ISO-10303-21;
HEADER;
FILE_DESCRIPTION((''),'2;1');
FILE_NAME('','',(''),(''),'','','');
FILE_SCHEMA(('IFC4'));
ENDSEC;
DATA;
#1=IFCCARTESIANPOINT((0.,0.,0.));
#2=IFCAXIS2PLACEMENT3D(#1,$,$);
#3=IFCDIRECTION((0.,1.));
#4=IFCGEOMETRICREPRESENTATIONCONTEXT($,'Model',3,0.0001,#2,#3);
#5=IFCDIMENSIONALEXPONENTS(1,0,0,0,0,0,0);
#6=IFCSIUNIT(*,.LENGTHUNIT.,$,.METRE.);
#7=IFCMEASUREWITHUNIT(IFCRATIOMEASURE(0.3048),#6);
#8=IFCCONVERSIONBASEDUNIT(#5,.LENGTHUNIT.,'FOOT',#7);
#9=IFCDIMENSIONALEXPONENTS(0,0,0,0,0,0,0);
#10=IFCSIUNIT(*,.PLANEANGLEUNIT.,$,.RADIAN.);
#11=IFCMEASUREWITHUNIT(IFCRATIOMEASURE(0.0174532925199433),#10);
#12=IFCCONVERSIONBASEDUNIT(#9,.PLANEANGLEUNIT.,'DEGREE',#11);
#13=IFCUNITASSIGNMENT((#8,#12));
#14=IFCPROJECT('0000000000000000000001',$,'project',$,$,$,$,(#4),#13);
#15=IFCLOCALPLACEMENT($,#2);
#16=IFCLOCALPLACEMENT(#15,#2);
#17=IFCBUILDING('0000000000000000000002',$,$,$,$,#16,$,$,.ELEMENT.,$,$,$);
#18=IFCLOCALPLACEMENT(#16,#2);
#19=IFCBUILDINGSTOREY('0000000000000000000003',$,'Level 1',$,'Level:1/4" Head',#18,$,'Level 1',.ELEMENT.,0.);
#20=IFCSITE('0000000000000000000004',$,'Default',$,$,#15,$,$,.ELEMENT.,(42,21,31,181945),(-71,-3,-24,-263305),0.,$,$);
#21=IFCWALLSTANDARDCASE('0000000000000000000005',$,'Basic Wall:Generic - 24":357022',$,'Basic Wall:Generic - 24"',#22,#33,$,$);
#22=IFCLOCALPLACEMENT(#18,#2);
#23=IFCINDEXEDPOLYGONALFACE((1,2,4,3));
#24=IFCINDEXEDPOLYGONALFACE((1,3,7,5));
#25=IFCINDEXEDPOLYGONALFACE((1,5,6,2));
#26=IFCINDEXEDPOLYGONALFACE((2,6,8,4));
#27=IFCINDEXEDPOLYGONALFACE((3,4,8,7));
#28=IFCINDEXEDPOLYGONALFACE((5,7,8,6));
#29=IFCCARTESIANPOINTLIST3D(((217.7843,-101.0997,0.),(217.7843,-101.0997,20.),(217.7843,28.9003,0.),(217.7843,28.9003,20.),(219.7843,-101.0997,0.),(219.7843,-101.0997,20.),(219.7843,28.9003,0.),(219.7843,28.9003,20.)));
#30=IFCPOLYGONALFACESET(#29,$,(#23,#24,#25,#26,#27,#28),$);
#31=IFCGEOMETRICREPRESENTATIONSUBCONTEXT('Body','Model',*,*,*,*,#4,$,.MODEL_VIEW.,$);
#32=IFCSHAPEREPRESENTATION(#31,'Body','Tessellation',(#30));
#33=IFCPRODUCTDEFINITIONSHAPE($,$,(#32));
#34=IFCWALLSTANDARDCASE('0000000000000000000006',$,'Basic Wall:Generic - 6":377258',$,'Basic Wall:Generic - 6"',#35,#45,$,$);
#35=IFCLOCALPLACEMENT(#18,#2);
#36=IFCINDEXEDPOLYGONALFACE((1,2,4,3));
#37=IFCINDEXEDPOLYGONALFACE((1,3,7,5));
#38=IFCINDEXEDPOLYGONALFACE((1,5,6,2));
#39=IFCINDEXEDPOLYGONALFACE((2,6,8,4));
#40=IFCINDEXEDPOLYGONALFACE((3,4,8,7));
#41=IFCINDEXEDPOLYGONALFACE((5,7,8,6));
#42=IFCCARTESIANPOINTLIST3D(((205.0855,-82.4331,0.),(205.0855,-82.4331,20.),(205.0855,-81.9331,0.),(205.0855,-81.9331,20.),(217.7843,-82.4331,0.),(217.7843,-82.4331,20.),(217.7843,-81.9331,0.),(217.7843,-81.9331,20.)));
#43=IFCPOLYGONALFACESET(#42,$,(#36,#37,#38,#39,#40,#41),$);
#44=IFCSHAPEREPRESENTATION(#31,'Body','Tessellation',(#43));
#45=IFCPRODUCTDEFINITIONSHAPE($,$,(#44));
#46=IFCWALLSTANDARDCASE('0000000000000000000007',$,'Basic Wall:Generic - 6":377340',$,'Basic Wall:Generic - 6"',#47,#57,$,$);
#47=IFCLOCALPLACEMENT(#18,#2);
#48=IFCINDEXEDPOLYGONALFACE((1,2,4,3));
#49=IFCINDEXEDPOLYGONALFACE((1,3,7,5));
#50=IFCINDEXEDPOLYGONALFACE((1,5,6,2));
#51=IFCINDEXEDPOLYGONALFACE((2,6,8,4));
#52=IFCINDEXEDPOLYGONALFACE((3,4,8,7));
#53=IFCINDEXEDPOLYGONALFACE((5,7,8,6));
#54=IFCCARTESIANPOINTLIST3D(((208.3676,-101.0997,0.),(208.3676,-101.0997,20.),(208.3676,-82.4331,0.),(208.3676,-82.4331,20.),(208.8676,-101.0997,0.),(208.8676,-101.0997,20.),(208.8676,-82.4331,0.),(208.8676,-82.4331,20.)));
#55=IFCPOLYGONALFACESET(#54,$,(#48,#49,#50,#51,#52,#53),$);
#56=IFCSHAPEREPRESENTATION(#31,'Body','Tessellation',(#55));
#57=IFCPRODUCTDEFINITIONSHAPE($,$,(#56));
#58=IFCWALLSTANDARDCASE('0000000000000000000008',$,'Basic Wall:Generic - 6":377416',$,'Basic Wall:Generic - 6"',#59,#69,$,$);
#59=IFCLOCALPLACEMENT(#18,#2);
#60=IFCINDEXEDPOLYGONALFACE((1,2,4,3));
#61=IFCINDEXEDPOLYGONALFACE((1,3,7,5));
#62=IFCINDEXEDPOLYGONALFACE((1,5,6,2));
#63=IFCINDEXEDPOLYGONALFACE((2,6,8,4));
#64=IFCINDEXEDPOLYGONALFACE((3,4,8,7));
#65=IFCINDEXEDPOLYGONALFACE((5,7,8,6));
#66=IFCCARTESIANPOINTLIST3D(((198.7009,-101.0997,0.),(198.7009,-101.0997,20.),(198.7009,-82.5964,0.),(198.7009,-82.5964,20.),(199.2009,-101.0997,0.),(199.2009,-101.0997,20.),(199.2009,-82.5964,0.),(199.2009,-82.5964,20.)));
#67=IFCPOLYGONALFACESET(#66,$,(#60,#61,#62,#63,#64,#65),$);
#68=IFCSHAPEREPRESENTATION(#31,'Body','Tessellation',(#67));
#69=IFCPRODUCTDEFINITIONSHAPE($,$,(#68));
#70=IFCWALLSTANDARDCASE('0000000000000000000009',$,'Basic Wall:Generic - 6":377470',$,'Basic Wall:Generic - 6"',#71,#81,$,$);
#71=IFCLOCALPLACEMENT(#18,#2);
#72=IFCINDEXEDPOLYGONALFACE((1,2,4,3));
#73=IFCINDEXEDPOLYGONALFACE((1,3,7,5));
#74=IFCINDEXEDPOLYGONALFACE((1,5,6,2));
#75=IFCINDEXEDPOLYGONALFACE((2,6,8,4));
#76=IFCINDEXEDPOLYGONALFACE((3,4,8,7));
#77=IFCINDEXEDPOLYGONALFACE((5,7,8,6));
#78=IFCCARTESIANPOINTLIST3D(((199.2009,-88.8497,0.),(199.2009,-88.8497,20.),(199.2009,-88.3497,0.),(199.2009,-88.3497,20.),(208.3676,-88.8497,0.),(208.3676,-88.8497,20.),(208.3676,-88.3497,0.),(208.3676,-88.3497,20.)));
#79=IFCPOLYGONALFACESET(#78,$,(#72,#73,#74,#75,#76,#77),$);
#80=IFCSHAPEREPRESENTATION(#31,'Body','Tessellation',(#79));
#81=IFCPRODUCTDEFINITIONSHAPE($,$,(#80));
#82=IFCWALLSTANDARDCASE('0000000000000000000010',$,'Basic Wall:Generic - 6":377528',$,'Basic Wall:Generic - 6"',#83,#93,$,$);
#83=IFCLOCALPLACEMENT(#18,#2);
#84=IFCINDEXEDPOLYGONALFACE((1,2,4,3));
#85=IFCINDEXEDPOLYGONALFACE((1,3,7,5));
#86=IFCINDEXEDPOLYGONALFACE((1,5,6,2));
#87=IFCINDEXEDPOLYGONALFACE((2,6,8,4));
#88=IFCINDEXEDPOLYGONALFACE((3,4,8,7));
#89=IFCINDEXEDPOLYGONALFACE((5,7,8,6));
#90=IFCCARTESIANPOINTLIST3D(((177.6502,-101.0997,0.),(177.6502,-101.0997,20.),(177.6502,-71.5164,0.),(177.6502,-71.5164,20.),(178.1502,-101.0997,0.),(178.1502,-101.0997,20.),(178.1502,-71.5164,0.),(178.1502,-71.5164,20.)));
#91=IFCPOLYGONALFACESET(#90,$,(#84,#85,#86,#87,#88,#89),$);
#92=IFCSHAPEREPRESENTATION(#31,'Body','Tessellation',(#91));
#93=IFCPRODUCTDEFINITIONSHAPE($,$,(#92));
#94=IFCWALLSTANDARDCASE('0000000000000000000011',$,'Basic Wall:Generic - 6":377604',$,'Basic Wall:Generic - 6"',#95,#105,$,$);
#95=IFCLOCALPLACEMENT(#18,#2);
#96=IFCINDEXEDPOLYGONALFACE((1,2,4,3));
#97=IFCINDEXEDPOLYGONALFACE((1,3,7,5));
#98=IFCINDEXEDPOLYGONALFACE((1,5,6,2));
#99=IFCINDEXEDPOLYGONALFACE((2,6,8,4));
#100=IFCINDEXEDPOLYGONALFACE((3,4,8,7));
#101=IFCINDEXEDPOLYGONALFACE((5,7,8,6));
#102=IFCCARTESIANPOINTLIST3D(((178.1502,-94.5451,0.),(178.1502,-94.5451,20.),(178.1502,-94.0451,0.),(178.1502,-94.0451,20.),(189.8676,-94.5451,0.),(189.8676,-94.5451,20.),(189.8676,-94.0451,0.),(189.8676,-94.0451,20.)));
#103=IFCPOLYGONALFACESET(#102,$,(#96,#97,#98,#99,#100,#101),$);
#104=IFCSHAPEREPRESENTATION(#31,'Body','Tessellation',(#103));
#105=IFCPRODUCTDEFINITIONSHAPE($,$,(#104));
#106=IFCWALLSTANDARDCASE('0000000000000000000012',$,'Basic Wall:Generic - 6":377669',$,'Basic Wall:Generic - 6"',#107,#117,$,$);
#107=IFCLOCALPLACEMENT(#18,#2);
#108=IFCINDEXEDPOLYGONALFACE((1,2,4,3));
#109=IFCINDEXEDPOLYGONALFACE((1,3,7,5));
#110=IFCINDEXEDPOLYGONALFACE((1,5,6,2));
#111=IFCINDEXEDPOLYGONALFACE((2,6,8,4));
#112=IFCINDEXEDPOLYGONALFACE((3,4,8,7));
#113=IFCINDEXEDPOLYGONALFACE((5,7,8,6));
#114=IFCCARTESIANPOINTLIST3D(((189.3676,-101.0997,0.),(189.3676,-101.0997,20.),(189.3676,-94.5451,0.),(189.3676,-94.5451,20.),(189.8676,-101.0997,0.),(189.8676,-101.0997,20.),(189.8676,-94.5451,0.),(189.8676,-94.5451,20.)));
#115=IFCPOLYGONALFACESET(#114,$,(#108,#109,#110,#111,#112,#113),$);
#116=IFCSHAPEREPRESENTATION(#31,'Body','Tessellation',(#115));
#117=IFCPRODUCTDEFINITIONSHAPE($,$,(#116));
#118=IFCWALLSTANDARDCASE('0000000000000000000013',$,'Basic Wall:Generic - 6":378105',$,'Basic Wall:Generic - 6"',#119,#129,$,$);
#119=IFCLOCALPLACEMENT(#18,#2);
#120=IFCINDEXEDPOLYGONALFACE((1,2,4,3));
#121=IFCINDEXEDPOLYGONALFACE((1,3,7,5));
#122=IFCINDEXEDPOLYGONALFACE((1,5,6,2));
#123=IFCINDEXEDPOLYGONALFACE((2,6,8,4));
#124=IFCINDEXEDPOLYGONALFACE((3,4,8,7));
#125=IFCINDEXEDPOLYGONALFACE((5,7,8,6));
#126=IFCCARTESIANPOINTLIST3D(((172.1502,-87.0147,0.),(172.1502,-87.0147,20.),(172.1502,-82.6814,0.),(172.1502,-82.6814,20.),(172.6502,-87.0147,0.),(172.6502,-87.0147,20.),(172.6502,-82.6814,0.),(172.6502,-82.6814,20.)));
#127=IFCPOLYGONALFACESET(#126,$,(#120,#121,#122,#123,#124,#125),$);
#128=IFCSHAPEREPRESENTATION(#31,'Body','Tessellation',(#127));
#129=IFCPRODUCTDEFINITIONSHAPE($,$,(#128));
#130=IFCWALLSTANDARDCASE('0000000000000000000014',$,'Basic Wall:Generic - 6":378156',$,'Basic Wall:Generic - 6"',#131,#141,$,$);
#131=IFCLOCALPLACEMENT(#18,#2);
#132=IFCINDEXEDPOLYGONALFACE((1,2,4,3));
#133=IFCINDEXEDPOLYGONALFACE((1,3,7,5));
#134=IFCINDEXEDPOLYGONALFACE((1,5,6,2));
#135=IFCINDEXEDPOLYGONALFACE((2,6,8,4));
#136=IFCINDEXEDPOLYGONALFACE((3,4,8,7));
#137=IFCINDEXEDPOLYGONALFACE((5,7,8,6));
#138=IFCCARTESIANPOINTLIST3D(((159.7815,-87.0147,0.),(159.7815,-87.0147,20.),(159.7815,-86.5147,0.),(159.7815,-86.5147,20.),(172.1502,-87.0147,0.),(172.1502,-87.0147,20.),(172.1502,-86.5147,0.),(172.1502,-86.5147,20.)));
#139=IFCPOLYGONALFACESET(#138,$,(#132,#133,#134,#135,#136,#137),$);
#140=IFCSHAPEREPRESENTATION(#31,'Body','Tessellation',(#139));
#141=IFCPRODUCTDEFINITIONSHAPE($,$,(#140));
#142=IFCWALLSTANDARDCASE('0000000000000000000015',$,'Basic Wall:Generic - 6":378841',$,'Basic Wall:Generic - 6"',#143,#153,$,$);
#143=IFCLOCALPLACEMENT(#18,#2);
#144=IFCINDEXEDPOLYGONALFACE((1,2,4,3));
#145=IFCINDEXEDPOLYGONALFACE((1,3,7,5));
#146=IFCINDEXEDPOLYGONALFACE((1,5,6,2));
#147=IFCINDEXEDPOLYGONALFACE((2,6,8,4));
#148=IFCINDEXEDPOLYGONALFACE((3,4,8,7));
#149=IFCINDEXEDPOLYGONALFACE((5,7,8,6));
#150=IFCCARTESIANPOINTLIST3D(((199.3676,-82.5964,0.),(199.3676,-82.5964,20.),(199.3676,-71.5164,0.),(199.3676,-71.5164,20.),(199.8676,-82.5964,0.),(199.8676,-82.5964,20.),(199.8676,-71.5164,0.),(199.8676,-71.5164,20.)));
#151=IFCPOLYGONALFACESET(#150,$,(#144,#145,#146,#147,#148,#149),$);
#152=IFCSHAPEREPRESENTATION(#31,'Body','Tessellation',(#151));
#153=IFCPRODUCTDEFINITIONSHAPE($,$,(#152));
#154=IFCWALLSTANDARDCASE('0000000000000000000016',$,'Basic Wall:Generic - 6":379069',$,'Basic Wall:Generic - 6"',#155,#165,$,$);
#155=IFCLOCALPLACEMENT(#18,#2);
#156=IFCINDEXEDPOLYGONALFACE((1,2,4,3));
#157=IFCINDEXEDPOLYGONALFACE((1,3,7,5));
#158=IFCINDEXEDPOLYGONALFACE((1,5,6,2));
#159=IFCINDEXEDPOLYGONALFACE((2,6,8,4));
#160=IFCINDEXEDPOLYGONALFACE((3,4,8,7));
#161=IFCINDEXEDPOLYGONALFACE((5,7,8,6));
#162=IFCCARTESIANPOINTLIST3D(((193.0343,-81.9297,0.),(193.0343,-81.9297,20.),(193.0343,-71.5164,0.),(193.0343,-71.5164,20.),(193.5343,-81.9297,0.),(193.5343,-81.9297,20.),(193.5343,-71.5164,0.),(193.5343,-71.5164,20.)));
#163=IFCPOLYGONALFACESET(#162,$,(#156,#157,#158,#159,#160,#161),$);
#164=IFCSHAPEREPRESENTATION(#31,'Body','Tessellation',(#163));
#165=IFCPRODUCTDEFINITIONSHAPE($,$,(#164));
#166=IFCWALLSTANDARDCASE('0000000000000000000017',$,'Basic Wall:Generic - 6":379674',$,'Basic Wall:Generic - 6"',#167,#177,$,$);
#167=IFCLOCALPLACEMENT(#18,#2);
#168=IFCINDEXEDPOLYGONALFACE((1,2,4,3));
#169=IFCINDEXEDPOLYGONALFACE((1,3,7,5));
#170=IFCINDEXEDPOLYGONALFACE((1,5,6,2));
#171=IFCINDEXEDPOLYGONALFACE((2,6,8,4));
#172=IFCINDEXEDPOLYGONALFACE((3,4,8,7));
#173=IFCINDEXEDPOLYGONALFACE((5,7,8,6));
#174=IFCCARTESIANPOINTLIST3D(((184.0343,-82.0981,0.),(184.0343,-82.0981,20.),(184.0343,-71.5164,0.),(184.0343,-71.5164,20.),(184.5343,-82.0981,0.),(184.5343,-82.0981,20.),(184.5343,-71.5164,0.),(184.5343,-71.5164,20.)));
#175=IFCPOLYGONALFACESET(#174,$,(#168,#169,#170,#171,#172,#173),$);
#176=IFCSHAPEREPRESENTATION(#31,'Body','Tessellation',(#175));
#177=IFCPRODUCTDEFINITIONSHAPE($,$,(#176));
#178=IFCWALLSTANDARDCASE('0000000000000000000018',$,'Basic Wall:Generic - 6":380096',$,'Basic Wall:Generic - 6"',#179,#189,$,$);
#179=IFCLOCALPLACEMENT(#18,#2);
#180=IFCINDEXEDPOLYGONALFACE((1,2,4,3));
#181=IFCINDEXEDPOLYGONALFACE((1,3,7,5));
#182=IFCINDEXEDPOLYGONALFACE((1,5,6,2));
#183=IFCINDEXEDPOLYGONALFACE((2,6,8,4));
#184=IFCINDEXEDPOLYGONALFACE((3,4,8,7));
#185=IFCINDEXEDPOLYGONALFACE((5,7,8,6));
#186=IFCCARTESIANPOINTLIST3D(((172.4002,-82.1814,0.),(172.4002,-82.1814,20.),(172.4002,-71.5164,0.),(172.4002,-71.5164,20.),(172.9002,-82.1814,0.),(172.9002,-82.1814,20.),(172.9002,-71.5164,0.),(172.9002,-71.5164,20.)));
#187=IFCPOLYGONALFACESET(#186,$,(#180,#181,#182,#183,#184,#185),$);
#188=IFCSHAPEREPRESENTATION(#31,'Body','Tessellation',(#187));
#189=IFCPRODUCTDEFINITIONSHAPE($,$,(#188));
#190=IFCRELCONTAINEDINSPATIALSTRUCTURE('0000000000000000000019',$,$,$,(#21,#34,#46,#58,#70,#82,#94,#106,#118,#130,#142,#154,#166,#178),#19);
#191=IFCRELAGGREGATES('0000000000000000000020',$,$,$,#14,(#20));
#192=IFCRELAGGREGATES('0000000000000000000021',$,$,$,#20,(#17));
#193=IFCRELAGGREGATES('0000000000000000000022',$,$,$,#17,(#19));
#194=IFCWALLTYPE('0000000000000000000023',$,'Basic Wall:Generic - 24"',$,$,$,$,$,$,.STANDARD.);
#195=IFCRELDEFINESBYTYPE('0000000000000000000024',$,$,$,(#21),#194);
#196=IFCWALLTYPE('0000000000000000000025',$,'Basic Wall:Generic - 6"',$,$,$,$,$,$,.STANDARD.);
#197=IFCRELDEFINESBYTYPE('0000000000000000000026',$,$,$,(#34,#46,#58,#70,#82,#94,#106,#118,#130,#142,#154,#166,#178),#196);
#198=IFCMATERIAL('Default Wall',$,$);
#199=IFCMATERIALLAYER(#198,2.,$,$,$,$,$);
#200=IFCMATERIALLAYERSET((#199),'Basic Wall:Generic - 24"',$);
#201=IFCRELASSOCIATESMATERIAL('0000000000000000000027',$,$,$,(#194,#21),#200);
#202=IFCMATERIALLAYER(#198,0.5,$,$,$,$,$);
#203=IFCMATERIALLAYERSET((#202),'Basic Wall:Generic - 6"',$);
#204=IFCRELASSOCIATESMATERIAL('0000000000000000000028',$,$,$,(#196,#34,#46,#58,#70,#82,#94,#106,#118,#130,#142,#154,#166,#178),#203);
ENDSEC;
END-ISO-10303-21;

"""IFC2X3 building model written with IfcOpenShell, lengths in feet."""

from ifc_helpers import new_model, entity, si_unit, converted_unit, direction, frame, frame_2d, origin, place, context, subcontext, project, spatial, rectangle, extrude, material, layer, layer_set, layer_usage, type_object, element, save


model = new_model("IFC2X3")

# Units and contexts
model_context = context("Model", 3, precision=0.0001, world=origin(), true_north=direction((0.0, 1.0)))
body_context = subcontext(model_context, "Body", "Model", "MODEL_VIEW")
ifc_project = project(units=[converted_unit("LENGTHUNIT", "FOOT", entity("IfcRatioMeasure", 0.3048), si_unit("LENGTHUNIT", "METRE"), dimensions=[1, 0, 0, 0, 0, 0, 0]), converted_unit("PLANEANGLEUNIT", "DEGREE", entity("IfcRatioMeasure", 0.0174532925199433), si_unit("PLANEANGLEUNIT", "RADIAN"), dimensions=[0, 0, 0, 0, 0, 0, 0])], contexts=[model_context])

# Site, building, storey
site_placement = place(None, origin())
site = spatial("IfcSite", under=ifc_project, at=site_placement, Name="Default", CompositionType="ELEMENT", RefLatitude=(42, 21, 31, 181945), RefLongitude=(-71, -3, -24, -263305), RefElevation=0.0)
building_placement = place(site_placement, origin())
building = spatial("IfcBuilding", under=site, at=building_placement, CompositionType="ELEMENT")
storey_placement = place(building_placement, origin())
storey = spatial("IfcBuildingStorey", under=building, at=storey_placement, Name="Level 1", ObjectType="Level:1/4\" Head", LongName="Level 1", CompositionType="ELEMENT", Elevation=0.0)

# Walls
ifc_material = material(Name="Default Wall")
ifc_layer_1 = layer(ifc_material, 2.0)
ifc_layer_set_1 = layer_set([ifc_layer_1], Name="Basic Wall:Generic - 24\"")
ifc_layer_usage_1 = layer_usage(ifc_layer_set_1, "AXIS2", "NEGATIVE", 1.0)
wall_type_1 = type_object("IfcWallType", Name="Basic Wall:Generic - 24\"", PredefinedType="STANDARD", material=ifc_layer_set_1)
wall_1_placement = place(storey_placement, frame((218.7843, -101.0997, 0.0), z_axis=(0.0, 0.0, 1.0), x_axis=(0.0, 1.0, 0.0)))
element("IfcWallStandardCase", 1, at=wall_1_placement, inside=storey, type_object=wall_type_1, material=ifc_layer_usage_1, Name="Basic Wall:Generic - 24\":357022", ObjectType="Basic Wall:Generic - 24\"", context=body_context, shape_type="SweptSolid", body=[
    extrude(rectangle(XDim=130.0, YDim=2.0, at=frame_2d((65.0, 0.0), x_axis=(-1.0, 0.0))), origin(), (0.0, 0.0, 1.0), 20.0),
])
ifc_layer_2 = layer(ifc_material, 0.5)
ifc_layer_set_2 = layer_set([ifc_layer_2], Name="Basic Wall:Generic - 6\"")
ifc_layer_usage_2 = layer_usage(ifc_layer_set_2, "AXIS2", "NEGATIVE", 0.25)
wall_type_2 = type_object("IfcWallType", Name="Basic Wall:Generic - 6\"", PredefinedType="STANDARD", material=ifc_layer_set_2)
wall_2_placement = place(storey_placement, frame((205.0855, -82.1831, 0.0)))
element("IfcWallStandardCase", 2, at=wall_2_placement, inside=storey, type_object=wall_type_2, material=ifc_layer_usage_2, Name="Basic Wall:Generic - 6\":377258", ObjectType="Basic Wall:Generic - 6\"", context=body_context, shape_type="SweptSolid", body=[
    extrude(rectangle(XDim=12.6987, YDim=0.5, at=frame_2d((6.3494, 0.0), x_axis=(-1.0, 0.0))), origin(), (0.0, 0.0, 1.0), 20.0),
])
ifc_layer_usage_3 = layer_usage(ifc_layer_set_2, "AXIS2", "NEGATIVE", 0.25)
wall_3_placement = place(storey_placement, frame((208.6176, -101.0997, 0.0), z_axis=(0.0, 0.0, 1.0), x_axis=(0.0, 1.0, 0.0)))
element("IfcWallStandardCase", 3, at=wall_3_placement, inside=storey, type_object=wall_type_2, material=ifc_layer_usage_3, Name="Basic Wall:Generic - 6\":377340", ObjectType="Basic Wall:Generic - 6\"", context=body_context, shape_type="SweptSolid", body=[
    extrude(rectangle(XDim=18.6667, YDim=0.5, at=frame_2d((9.3333, 0.0), x_axis=(-1.0, 0.0))), origin(), (0.0, 0.0, 1.0), 20.0),
])
ifc_layer_usage_4 = layer_usage(ifc_layer_set_2, "AXIS2", "NEGATIVE", 0.25)
wall_4_placement = place(storey_placement, frame((198.9509, -82.5964, 0.0), z_axis=(0.0, 0.0, 1.0), x_axis=(0.0, -1.0, 0.0)))
element("IfcWallStandardCase", 4, at=wall_4_placement, inside=storey, type_object=wall_type_2, material=ifc_layer_usage_4, Name="Basic Wall:Generic - 6\":377416", ObjectType="Basic Wall:Generic - 6\"", context=body_context, shape_type="SweptSolid", body=[
    extrude(rectangle(XDim=18.5033, YDim=0.5, at=frame_2d((9.2517, 0.0), x_axis=(-1.0, 0.0))), origin(), (0.0, 0.0, 1.0), 20.0),
])
ifc_layer_usage_5 = layer_usage(ifc_layer_set_2, "AXIS2", "NEGATIVE", 0.25)
wall_5_placement = place(storey_placement, frame((199.2009, -88.5997, 0.0)))
element("IfcWallStandardCase", 5, at=wall_5_placement, inside=storey, type_object=wall_type_2, material=ifc_layer_usage_5, Name="Basic Wall:Generic - 6\":377470", ObjectType="Basic Wall:Generic - 6\"", context=body_context, shape_type="SweptSolid", body=[
    extrude(rectangle(XDim=9.1667, YDim=0.5, at=frame_2d((4.5833, 0.0), x_axis=(-1.0, 0.0))), origin(), (0.0, 0.0, 1.0), 20.0),
])
ifc_layer_usage_6 = layer_usage(ifc_layer_set_2, "AXIS2", "NEGATIVE", 0.25)
wall_6_placement = place(storey_placement, frame((177.9002, -101.0997, 0.0), z_axis=(0.0, 0.0, 1.0), x_axis=(0.0, 1.0, 0.0)))
element("IfcWallStandardCase", 6, at=wall_6_placement, inside=storey, type_object=wall_type_2, material=ifc_layer_usage_6, Name="Basic Wall:Generic - 6\":377528", ObjectType="Basic Wall:Generic - 6\"", context=body_context, shape_type="SweptSolid", body=[
    extrude(rectangle(XDim=29.5833, YDim=0.5, at=frame_2d((14.7917, 0.0), x_axis=(-1.0, 0.0))), origin(), (0.0, 0.0, 1.0), 20.0),
])
ifc_layer_usage_7 = layer_usage(ifc_layer_set_2, "AXIS2", "NEGATIVE", 0.25)
wall_7_placement = place(storey_placement, frame((178.1502, -94.2951, 0.0)))
element("IfcWallStandardCase", 7, at=wall_7_placement, inside=storey, type_object=wall_type_2, material=ifc_layer_usage_7, Name="Basic Wall:Generic - 6\":377604", ObjectType="Basic Wall:Generic - 6\"", context=body_context, shape_type="SweptSolid", body=[
    extrude(rectangle(XDim=11.7174, YDim=0.5, at=frame_2d((5.8587, 0.0), x_axis=(-1.0, 0.0))), origin(), (0.0, 0.0, 1.0), 20.0),
])
ifc_layer_usage_8 = layer_usage(ifc_layer_set_2, "AXIS2", "NEGATIVE", 0.25)
wall_8_placement = place(storey_placement, frame((189.6176, -94.5451, 0.0), z_axis=(0.0, 0.0, 1.0), x_axis=(0.0, -1.0, 0.0)))
element("IfcWallStandardCase", 8, at=wall_8_placement, inside=storey, type_object=wall_type_2, material=ifc_layer_usage_8, Name="Basic Wall:Generic - 6\":377669", ObjectType="Basic Wall:Generic - 6\"", context=body_context, shape_type="SweptSolid", body=[
    extrude(rectangle(XDim=6.5547, YDim=0.5, at=frame_2d((3.2773, 0.0), x_axis=(-1.0, 0.0))), origin(), (0.0, 0.0, 1.0), 20.0),
])
ifc_layer_usage_9 = layer_usage(ifc_layer_set_2, "AXIS2", "NEGATIVE", 0.25)
wall_9_placement = place(storey_placement, frame((172.4002, -82.6814, 0.0), z_axis=(0.0, 0.0, 1.0), x_axis=(0.0, -1.0, 0.0)))
element("IfcWallStandardCase", 9, at=wall_9_placement, inside=storey, type_object=wall_type_2, material=ifc_layer_usage_9, Name="Basic Wall:Generic - 6\":378105", ObjectType="Basic Wall:Generic - 6\"", context=body_context, shape_type="SweptSolid", body=[
    extrude(rectangle(XDim=4.3333, YDim=0.5, at=frame_2d((2.1667, 0.0), x_axis=(-1.0, 0.0))), origin(), (0.0, 0.0, 1.0), 20.0),
])
ifc_layer_usage_10 = layer_usage(ifc_layer_set_2, "AXIS2", "NEGATIVE", 0.25)
wall_10_placement = place(storey_placement, frame((172.1502, -86.7647, 0.0), z_axis=(0.0, 0.0, 1.0), x_axis=(-1.0, 0.0, 0.0)))
element("IfcWallStandardCase", 10, at=wall_10_placement, inside=storey, type_object=wall_type_2, material=ifc_layer_usage_10, Name="Basic Wall:Generic - 6\":378156", ObjectType="Basic Wall:Generic - 6\"", context=body_context, shape_type="SweptSolid", body=[
    extrude(rectangle(XDim=12.3687, YDim=0.5, at=frame_2d((6.1843, 0.0), x_axis=(-1.0, 0.0))), origin(), (0.0, 0.0, 1.0), 20.0),
])
ifc_layer_usage_11 = layer_usage(ifc_layer_set_2, "AXIS2", "NEGATIVE", 0.25)
wall_11_placement = place(storey_placement, frame((199.6176, -71.5164, 0.0), z_axis=(0.0, 0.0, 1.0), x_axis=(0.0, -1.0, 0.0)))
element("IfcWallStandardCase", 11, at=wall_11_placement, inside=storey, type_object=wall_type_2, material=ifc_layer_usage_11, Name="Basic Wall:Generic - 6\":378841", ObjectType="Basic Wall:Generic - 6\"", context=body_context, shape_type="SweptSolid", body=[
    extrude(rectangle(XDim=11.08, YDim=0.5, at=frame_2d((5.54, 0.0), x_axis=(-1.0, 0.0))), origin(), (0.0, 0.0, 1.0), 20.0),
])
ifc_layer_usage_12 = layer_usage(ifc_layer_set_2, "AXIS2", "NEGATIVE", 0.25)
wall_12_placement = place(storey_placement, frame((193.2843, -81.9297, 0.0), z_axis=(0.0, 0.0, 1.0), x_axis=(0.0, 1.0, 0.0)))
element("IfcWallStandardCase", 12, at=wall_12_placement, inside=storey, type_object=wall_type_2, material=ifc_layer_usage_12, Name="Basic Wall:Generic - 6\":379069", ObjectType="Basic Wall:Generic - 6\"", context=body_context, shape_type="SweptSolid", body=[
    extrude(rectangle(XDim=10.4133, YDim=0.5, at=frame_2d((5.2067, 0.0), x_axis=(-1.0, 0.0))), origin(), (0.0, 0.0, 1.0), 20.0),
])
ifc_layer_usage_13 = layer_usage(ifc_layer_set_2, "AXIS2", "NEGATIVE", 0.25)
wall_13_placement = place(storey_placement, frame((184.2843, -82.0981, 0.0), z_axis=(0.0, 0.0, 1.0), x_axis=(0.0, 1.0, 0.0)))
element("IfcWallStandardCase", 13, at=wall_13_placement, inside=storey, type_object=wall_type_2, material=ifc_layer_usage_13, Name="Basic Wall:Generic - 6\":379674", ObjectType="Basic Wall:Generic - 6\"", context=body_context, shape_type="SweptSolid", body=[
    extrude(rectangle(XDim=10.5817, YDim=0.5, at=frame_2d((5.2908, 0.0), x_axis=(-1.0, 0.0))), origin(), (0.0, 0.0, 1.0), 20.0),
])
ifc_layer_usage_14 = layer_usage(ifc_layer_set_2, "AXIS2", "NEGATIVE", 0.25)
wall_14_placement = place(storey_placement, frame((172.6502, -82.1814, 0.0), z_axis=(0.0, 0.0, 1.0), x_axis=(0.0, 1.0, 0.0)))
element("IfcWallStandardCase", 14, at=wall_14_placement, inside=storey, type_object=wall_type_2, material=ifc_layer_usage_14, Name="Basic Wall:Generic - 6\":380096", ObjectType="Basic Wall:Generic - 6\"", context=body_context, shape_type="SweptSolid", body=[
    extrude(rectangle(XDim=10.665, YDim=0.5, at=frame_2d((5.3325, 0.0), x_axis=(-1.0, 0.0))), origin(), (0.0, 0.0, 1.0), 20.0),
])

save(model, "model.ifc")
